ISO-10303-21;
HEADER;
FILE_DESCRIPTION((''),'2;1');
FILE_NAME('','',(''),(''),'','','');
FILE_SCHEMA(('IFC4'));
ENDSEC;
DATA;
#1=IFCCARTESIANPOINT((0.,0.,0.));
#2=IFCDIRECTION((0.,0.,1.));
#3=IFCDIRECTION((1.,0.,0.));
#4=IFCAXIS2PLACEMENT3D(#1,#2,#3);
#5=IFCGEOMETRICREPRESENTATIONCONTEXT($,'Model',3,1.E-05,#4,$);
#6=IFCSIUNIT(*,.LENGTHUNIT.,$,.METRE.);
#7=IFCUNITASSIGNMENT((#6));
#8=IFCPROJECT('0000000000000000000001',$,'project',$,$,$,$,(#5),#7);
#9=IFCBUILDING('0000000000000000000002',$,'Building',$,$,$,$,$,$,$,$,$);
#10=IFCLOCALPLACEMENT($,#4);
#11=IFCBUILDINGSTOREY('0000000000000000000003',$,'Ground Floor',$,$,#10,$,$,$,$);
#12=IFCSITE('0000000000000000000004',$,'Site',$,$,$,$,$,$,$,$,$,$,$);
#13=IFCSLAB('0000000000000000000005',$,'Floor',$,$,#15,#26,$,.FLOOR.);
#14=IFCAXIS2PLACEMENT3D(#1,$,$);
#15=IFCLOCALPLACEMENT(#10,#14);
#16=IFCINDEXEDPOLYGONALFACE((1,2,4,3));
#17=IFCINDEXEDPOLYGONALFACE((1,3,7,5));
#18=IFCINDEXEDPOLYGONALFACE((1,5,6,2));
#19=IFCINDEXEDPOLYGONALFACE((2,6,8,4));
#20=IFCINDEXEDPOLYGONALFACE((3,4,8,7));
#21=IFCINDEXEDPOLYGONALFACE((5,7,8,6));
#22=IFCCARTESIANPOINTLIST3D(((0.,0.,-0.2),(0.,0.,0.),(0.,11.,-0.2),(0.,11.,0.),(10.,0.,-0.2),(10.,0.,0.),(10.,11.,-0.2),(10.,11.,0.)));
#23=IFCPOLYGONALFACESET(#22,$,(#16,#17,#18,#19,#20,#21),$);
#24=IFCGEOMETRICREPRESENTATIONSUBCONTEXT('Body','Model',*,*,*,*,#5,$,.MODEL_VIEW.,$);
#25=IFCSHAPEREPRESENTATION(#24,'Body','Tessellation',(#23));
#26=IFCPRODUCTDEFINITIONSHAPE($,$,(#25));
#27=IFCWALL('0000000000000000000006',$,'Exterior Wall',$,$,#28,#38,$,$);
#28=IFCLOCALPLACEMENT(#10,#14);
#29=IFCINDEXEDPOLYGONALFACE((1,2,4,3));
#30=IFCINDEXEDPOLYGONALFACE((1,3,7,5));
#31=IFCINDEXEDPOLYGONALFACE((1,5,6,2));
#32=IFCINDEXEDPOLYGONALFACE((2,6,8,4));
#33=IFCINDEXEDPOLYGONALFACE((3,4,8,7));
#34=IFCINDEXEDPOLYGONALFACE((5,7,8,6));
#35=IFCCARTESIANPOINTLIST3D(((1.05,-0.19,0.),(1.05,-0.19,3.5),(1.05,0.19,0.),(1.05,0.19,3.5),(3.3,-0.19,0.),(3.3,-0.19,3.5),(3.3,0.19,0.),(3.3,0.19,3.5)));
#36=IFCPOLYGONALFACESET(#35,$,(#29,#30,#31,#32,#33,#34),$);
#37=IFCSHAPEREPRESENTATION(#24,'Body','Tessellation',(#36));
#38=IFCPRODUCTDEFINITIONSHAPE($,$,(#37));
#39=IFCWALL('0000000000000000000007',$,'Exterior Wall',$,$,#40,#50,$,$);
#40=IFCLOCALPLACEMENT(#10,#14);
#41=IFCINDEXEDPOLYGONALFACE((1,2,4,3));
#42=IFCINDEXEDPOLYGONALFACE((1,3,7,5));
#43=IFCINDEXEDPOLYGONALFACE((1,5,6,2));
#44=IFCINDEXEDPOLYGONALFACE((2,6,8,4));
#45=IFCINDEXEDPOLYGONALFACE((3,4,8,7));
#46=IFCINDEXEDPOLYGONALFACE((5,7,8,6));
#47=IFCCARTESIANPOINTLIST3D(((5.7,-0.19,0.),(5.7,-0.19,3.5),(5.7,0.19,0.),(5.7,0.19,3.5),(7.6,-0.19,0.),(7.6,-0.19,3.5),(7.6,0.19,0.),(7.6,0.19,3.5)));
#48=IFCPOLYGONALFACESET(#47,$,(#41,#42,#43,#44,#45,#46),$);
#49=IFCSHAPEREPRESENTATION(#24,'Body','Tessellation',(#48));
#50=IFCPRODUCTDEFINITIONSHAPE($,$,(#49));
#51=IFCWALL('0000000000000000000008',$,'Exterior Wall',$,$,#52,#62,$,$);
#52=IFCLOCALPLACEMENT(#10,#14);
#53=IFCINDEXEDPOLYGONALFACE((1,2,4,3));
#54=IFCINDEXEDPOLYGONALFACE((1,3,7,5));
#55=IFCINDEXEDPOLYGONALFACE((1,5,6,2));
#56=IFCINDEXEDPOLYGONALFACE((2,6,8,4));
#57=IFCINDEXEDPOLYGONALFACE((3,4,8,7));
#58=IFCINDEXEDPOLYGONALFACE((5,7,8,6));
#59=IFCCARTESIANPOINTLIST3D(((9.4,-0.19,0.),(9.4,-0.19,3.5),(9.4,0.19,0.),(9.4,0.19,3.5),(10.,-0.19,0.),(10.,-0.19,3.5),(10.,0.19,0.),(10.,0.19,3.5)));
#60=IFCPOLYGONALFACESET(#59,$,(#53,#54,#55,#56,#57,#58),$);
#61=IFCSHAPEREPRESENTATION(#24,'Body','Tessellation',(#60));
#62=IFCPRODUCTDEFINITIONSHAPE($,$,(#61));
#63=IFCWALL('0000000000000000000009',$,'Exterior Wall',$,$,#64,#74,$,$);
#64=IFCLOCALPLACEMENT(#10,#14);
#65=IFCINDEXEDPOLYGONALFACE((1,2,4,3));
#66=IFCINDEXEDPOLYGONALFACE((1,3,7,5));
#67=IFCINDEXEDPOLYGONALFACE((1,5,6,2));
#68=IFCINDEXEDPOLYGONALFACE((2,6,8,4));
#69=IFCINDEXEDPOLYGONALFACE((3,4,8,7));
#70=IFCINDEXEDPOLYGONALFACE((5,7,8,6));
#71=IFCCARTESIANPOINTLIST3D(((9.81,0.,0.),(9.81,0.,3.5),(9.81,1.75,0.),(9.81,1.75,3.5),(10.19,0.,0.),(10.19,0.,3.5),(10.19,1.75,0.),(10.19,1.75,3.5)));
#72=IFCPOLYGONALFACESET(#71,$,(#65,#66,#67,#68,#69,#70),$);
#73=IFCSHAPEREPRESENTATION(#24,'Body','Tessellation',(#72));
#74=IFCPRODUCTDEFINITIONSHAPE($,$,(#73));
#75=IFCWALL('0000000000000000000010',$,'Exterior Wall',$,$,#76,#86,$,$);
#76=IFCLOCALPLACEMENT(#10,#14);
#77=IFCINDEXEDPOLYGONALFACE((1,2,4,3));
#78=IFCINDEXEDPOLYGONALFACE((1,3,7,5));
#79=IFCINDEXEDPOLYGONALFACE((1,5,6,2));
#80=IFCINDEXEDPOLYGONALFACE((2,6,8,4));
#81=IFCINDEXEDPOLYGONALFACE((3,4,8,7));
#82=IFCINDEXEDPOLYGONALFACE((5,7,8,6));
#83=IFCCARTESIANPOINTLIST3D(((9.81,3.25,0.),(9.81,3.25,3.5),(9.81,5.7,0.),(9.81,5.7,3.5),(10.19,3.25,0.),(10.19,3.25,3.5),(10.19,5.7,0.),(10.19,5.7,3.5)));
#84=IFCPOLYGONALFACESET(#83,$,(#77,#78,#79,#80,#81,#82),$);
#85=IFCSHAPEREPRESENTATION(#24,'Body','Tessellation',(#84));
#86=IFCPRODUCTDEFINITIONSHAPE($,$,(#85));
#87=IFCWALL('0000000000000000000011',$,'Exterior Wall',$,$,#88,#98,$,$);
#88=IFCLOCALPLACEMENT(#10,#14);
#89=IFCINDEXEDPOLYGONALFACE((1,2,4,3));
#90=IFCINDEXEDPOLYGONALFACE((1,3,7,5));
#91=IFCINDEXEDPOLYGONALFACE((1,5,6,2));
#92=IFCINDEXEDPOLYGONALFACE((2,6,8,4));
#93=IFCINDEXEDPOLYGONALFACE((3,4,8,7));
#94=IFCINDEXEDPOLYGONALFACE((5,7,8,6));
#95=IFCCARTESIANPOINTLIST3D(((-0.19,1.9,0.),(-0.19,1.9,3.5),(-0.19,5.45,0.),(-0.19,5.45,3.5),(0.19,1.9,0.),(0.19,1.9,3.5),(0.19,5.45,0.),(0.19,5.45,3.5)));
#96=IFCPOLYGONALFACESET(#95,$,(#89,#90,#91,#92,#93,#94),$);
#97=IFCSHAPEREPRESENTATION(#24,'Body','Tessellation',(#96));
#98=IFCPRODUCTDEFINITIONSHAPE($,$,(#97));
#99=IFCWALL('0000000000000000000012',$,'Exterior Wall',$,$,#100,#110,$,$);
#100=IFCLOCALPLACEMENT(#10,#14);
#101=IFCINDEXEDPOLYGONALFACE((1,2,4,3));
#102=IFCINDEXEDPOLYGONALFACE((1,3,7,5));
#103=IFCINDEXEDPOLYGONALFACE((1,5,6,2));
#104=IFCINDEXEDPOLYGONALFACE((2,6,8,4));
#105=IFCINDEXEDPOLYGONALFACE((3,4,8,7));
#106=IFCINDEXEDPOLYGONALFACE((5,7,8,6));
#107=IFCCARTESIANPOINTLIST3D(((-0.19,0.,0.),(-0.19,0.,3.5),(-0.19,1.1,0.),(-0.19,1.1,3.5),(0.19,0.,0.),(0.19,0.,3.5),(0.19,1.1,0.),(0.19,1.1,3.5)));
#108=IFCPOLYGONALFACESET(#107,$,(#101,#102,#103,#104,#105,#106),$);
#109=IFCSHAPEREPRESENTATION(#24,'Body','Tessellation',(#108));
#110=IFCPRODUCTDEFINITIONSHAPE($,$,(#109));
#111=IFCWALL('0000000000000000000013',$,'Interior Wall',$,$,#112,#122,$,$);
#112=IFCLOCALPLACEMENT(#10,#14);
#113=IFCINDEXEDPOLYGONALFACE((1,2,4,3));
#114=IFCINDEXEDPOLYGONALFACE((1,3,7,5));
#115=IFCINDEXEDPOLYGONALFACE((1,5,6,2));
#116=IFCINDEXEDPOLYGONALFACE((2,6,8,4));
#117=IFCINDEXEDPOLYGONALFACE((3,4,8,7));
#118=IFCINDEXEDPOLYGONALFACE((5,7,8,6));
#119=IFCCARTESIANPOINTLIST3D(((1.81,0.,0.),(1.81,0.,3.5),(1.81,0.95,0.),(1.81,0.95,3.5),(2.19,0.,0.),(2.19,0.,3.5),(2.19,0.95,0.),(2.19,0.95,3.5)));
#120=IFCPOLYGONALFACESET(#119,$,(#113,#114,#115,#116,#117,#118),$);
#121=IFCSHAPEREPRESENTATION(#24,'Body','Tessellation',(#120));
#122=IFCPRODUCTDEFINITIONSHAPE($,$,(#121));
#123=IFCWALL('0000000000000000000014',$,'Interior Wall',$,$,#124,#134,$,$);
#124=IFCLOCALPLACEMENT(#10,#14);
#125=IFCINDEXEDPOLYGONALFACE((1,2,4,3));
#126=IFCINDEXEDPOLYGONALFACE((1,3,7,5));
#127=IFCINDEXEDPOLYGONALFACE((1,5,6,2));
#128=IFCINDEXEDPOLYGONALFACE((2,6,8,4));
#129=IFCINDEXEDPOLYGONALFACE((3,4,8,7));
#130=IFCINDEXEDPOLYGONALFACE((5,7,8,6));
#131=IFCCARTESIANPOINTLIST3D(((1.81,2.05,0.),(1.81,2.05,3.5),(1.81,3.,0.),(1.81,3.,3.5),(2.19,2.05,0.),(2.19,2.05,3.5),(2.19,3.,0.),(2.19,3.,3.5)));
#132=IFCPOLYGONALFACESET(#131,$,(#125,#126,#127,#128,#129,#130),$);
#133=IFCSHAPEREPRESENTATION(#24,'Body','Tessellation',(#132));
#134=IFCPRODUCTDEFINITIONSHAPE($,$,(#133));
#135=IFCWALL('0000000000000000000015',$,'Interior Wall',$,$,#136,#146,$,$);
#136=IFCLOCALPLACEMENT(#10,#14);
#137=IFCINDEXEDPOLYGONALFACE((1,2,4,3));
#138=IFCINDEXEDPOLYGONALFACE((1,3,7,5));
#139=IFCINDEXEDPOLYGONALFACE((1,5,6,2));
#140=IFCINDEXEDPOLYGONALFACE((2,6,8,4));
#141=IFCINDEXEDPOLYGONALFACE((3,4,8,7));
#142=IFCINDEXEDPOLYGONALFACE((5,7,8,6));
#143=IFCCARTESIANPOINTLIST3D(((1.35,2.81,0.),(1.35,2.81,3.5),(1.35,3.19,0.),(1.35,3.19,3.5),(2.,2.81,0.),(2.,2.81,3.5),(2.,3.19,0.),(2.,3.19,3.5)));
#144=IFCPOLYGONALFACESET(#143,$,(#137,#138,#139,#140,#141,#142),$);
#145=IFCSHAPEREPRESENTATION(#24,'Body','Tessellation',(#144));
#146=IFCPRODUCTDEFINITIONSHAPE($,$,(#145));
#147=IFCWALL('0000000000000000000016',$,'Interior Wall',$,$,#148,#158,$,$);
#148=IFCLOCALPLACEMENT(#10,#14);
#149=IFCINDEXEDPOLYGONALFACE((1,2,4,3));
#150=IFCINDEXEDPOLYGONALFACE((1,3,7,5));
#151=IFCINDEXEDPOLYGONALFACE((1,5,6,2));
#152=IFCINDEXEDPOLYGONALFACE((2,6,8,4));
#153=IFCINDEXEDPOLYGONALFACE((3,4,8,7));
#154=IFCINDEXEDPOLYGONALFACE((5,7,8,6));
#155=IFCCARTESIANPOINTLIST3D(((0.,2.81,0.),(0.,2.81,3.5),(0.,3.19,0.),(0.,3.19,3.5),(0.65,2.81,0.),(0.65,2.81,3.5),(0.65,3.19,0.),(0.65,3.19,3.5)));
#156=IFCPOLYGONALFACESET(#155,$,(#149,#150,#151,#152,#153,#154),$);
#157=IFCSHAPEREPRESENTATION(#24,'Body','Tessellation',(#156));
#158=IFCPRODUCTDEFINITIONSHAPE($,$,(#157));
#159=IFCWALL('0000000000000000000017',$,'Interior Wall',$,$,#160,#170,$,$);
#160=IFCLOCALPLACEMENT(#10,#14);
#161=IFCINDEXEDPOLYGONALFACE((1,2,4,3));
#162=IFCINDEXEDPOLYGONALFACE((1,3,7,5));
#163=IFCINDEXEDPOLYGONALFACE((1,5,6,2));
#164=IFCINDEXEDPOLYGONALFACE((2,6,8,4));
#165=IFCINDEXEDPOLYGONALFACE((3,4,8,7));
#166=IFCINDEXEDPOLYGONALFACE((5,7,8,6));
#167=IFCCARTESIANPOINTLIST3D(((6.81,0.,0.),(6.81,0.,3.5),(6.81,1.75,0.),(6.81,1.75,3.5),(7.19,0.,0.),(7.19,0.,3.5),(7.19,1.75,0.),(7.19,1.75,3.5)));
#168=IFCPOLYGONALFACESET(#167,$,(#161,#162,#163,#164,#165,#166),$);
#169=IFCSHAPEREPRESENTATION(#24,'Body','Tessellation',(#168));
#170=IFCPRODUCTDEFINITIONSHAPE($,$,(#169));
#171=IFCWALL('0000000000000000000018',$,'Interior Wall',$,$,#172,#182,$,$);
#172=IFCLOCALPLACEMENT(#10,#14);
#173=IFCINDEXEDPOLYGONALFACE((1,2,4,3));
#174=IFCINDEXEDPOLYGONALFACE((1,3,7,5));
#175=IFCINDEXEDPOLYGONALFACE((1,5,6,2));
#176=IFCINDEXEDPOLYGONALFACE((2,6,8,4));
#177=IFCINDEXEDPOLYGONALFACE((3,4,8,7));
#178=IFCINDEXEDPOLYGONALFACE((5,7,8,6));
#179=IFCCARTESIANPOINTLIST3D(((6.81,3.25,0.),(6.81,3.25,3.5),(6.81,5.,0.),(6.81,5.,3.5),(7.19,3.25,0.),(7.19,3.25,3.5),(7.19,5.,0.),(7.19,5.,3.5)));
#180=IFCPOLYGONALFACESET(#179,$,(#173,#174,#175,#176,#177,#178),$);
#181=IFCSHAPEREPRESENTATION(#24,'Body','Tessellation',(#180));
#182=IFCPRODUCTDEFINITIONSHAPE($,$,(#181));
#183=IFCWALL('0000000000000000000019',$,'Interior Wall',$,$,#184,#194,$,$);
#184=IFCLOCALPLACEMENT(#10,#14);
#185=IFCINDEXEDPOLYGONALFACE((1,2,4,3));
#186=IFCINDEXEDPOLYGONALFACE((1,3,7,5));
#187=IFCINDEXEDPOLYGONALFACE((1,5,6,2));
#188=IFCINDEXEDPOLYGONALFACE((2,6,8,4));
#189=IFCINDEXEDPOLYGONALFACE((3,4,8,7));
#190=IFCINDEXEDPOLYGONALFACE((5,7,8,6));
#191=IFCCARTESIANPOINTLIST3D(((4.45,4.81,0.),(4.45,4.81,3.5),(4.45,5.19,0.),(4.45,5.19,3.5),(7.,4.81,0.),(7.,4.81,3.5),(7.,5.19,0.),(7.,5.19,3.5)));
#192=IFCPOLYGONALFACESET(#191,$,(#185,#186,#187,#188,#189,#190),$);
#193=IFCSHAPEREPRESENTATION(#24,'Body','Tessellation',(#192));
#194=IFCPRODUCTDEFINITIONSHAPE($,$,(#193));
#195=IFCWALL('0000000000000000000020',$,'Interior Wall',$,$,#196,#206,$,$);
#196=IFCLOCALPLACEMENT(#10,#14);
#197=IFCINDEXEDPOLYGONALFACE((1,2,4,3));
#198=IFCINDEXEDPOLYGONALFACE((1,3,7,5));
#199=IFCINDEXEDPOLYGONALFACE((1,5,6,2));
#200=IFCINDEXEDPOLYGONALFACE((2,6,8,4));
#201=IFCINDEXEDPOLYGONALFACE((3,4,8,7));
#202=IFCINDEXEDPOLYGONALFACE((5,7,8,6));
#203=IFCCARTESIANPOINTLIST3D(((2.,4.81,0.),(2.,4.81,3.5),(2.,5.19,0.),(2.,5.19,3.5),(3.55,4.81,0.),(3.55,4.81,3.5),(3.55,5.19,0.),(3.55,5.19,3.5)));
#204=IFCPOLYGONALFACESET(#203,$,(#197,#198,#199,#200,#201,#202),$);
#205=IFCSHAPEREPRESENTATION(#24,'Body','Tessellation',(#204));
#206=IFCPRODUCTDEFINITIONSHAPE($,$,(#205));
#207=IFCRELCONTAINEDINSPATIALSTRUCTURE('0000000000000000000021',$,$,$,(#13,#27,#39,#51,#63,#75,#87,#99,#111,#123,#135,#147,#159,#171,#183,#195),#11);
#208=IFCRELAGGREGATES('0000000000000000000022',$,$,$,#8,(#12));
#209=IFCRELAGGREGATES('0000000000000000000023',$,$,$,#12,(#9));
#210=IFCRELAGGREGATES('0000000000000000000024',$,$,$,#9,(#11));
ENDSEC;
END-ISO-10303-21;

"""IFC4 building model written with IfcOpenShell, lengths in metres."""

from ifc_helpers import new_model, si_unit, frame, origin_with_axes, place, context, subcontext, project, spatial, indexed_curve, outline, extrude, element, save


model = new_model("IFC4")

# Units and contexts
model_context = context("Model", 3, precision=1e-05, world=origin_with_axes())
body_context = subcontext(model_context, "Body", "Model", "MODEL_VIEW")
ifc_project = project(units=[si_unit("LENGTHUNIT", "METRE")], contexts=[model_context])

# Site, building, storey
site = spatial("IfcSite", under=ifc_project, Name="Site")
building = spatial("IfcBuilding", under=site, Name="Building")
storey_placement = place(None, origin_with_axes())
storey = spatial("IfcBuildingStorey", under=building, at=storey_placement, Name="Ground Floor")

# Slab
slab_placement = place(storey_placement, frame((0.0, 0.0, -0.2), z_axis=(0.0, 0.0, 1.0), x_axis=(1.0, 0.0, 0.0)))
element("IfcSlab", 1, at=slab_placement, inside=storey, Name="Floor", PredefinedType="FLOOR", context=body_context, shape_type="SweptSolid", body=[
    extrude(outline(indexed_curve([(0.0, 0.0), (10.0, 0.0), (10.0, 11.0), (0.0, 11.0)])), None, (0.0, 0.0, 1.0), 0.2),
])

# Walls
wall_1_placement = place(storey_placement, frame((1.05, 0.0, 0.0), z_axis=(0.0, 0.0, 1.0), x_axis=(1.0, 0.0, 0.0)))
element("IfcWall", 2, at=wall_1_placement, inside=storey, Name="Exterior Wall", context=body_context, shape_type="SweptSolid", body=[
    extrude(outline(indexed_curve([(0.0, 0.0), (0.0, 0.38), (2.25, 0.38), (2.25, 0.0), (0.0, 0.0)], self_intersect=False)), frame((0.0, -0.19, 0.0), z_axis=(0.0, 0.0, 1.0), x_axis=(1.0, 0.0, 0.0)), (0.0, 0.0, 1.0), 3.5),
])
wall_2_placement = place(storey_placement, frame((5.7, 0.0, 0.0), z_axis=(0.0, 0.0, 1.0), x_axis=(1.0, 0.0, 0.0)))
element("IfcWall", 3, at=wall_2_placement, inside=storey, Name="Exterior Wall", context=body_context, shape_type="SweptSolid", body=[
    extrude(outline(indexed_curve([(0.0, 0.0), (0.0, 0.38), (1.9, 0.38), (1.9, 0.0), (0.0, 0.0)], self_intersect=False)), frame((0.0, -0.19, 0.0), z_axis=(0.0, 0.0, 1.0), x_axis=(1.0, 0.0, 0.0)), (0.0, 0.0, 1.0), 3.5),
])
wall_3_placement = place(storey_placement, frame((9.4, 0.0, 0.0), z_axis=(0.0, 0.0, 1.0), x_axis=(1.0, 0.0, 0.0)))
element("IfcWall", 4, at=wall_3_placement, inside=storey, Name="Exterior Wall", context=body_context, shape_type="SweptSolid", body=[
    extrude(outline(indexed_curve([(0.0, 0.0), (0.0, 0.38), (0.6, 0.38), (0.6, 0.0), (0.0, 0.0)], self_intersect=False)), frame((0.0, -0.19, 0.0), z_axis=(0.0, 0.0, 1.0), x_axis=(1.0, 0.0, 0.0)), (0.0, 0.0, 1.0), 3.5),
])
wall_4_placement = place(storey_placement, frame((10.0, 0.0, 0.0), z_axis=(0.0, 0.0, 1.0), x_axis=(0.0, 1.0, 0.0)))
element("IfcWall", 5, at=wall_4_placement, inside=storey, Name="Exterior Wall", context=body_context, shape_type="SweptSolid", body=[
    extrude(outline(indexed_curve([(0.0, 0.0), (0.0, 0.38), (1.75, 0.38), (1.75, 0.0), (0.0, 0.0)], self_intersect=False)), frame((0.0, -0.19, 0.0), z_axis=(0.0, 0.0, 1.0), x_axis=(1.0, 0.0, 0.0)), (0.0, 0.0, 1.0), 3.5),
])
wall_5_placement = place(storey_placement, frame((10.0, 3.25, 0.0), z_axis=(0.0, 0.0, 1.0), x_axis=(0.0, 1.0, 0.0)))
element("IfcWall", 6, at=wall_5_placement, inside=storey, Name="Exterior Wall", context=body_context, shape_type="SweptSolid", body=[
    extrude(outline(indexed_curve([(0.0, 0.0), (0.0, 0.38), (2.45, 0.38), (2.45, 0.0), (0.0, 0.0)], self_intersect=False)), frame((0.0, -0.19, 0.0), z_axis=(0.0, 0.0, 1.0), x_axis=(1.0, 0.0, 0.0)), (0.0, 0.0, 1.0), 3.5),
])
wall_6_placement = place(storey_placement, frame((0.0, 5.45, 0.0), z_axis=(0.0, 0.0, 1.0), x_axis=(0.0, -1.0, 0.0)))
element("IfcWall", 7, at=wall_6_placement, inside=storey, Name="Exterior Wall", context=body_context, shape_type="SweptSolid", body=[
    extrude(outline(indexed_curve([(0.0, 0.0), (0.0, 0.38), (3.55, 0.38), (3.55, 0.0), (0.0, 0.0)], self_intersect=False)), frame((0.0, -0.19, 0.0), z_axis=(0.0, 0.0, 1.0), x_axis=(1.0, 0.0, 0.0)), (0.0, 0.0, 1.0), 3.5),
])
wall_7_placement = place(storey_placement, frame((0.0, 1.1, 0.0), z_axis=(0.0, 0.0, 1.0), x_axis=(0.0, -1.0, 0.0)))
element("IfcWall", 8, at=wall_7_placement, inside=storey, Name="Exterior Wall", context=body_context, shape_type="SweptSolid", body=[
    extrude(outline(indexed_curve([(0.0, 0.0), (0.0, 0.38), (1.1, 0.38), (1.1, 0.0), (0.0, 0.0)], self_intersect=False)), frame((0.0, -0.19, 0.0), z_axis=(0.0, 0.0, 1.0), x_axis=(1.0, 0.0, 0.0)), (0.0, 0.0, 1.0), 3.5),
])
wall_8_placement = place(storey_placement, frame((2.0, 0.0, 0.0), z_axis=(0.0, 0.0, 1.0), x_axis=(0.0, 1.0, 0.0)))
element("IfcWall", 9, at=wall_8_placement, inside=storey, Name="Interior Wall", context=body_context, shape_type="SweptSolid", body=[
    extrude(outline(indexed_curve([(0.0, 0.0), (0.0, 0.38), (0.95, 0.38), (0.95, 0.0), (0.0, 0.0)], self_intersect=False)), frame((0.0, -0.19, 0.0), z_axis=(0.0, 0.0, 1.0), x_axis=(1.0, 0.0, 0.0)), (0.0, 0.0, 1.0), 3.5),
])
wall_9_placement = place(storey_placement, frame((2.0, 2.05, 0.0), z_axis=(0.0, 0.0, 1.0), x_axis=(0.0, 1.0, 0.0)))
element("IfcWall", 10, at=wall_9_placement, inside=storey, Name="Interior Wall", context=body_context, shape_type="SweptSolid", body=[
    extrude(outline(indexed_curve([(0.0, 0.0), (0.0, 0.38), (0.95, 0.38), (0.95, 0.0), (0.0, 0.0)], self_intersect=False)), frame((0.0, -0.19, 0.0), z_axis=(0.0, 0.0, 1.0), x_axis=(1.0, 0.0, 0.0)), (0.0, 0.0, 1.0), 3.5),
])
for number, where, z_axis, x_axis, name in (
    (11, (2.0, 3.0, 0.0), (0.0, 0.0, 1.0), (-1.0, 0.0, 0.0), "Interior Wall"),
    (12, (0.65, 3.0, 0.0), (0.0, 0.0, 1.0), (-1.0, 0.0, 0.0), "Interior Wall"),
):
    element("IfcWall", number, at=place(storey_placement, frame(where, z_axis=z_axis, x_axis=x_axis)), inside=storey, Name=name, context=body_context, shape_type="SweptSolid", body=[
        extrude(outline(indexed_curve([(0.0, 0.0), (0.0, 0.38), (0.65, 0.38), (0.65, 0.0), (0.0, 0.0)], self_intersect=False)), frame((0.0, -0.19, 0.0), z_axis=(0.0, 0.0, 1.0), x_axis=(1.0, 0.0, 0.0)), (0.0, 0.0, 1.0), 3.5),
    ])
for number, where, z_axis, x_axis, name in (
    (13, (7.0, 0.0, 0.0), (0.0, 0.0, 1.0), (0.0, 1.0, 0.0), "Interior Wall"),
    (14, (7.0, 3.25, 0.0), (0.0, 0.0, 1.0), (0.0, 1.0, 0.0), "Interior Wall"),
):
    element("IfcWall", number, at=place(storey_placement, frame(where, z_axis=z_axis, x_axis=x_axis)), inside=storey, Name=name, context=body_context, shape_type="SweptSolid", body=[
        extrude(outline(indexed_curve([(0.0, 0.0), (0.0, 0.38), (1.75, 0.38), (1.75, 0.0), (0.0, 0.0)], self_intersect=False)), frame((0.0, -0.19, 0.0), z_axis=(0.0, 0.0, 1.0), x_axis=(1.0, 0.0, 0.0)), (0.0, 0.0, 1.0), 3.5),
    ])
wall_10_placement = place(storey_placement, frame((7.0, 5.0, 0.0), z_axis=(0.0, 0.0, 1.0), x_axis=(-1.0, 0.0, 0.0)))
element("IfcWall", 15, at=wall_10_placement, inside=storey, Name="Interior Wall", context=body_context, shape_type="SweptSolid", body=[
    extrude(outline(indexed_curve([(0.0, 0.0), (0.0, 0.38), (2.55, 0.38), (2.55, 0.0), (0.0, 0.0)], self_intersect=False)), frame((0.0, -0.19, 0.0), z_axis=(0.0, 0.0, 1.0), x_axis=(1.0, 0.0, 0.0)), (0.0, 0.0, 1.0), 3.5),
])
wall_11_placement = place(storey_placement, frame((3.55, 5.0, 0.0), z_axis=(0.0, 0.0, 1.0), x_axis=(-1.0, 0.0, 0.0)))
element("IfcWall", 16, at=wall_11_placement, inside=storey, Name="Interior Wall", context=body_context, shape_type="SweptSolid", body=[
    extrude(outline(indexed_curve([(0.0, 0.0), (0.0, 0.38), (1.55, 0.38), (1.55, 0.0), (0.0, 0.0)], self_intersect=False)), frame((0.0, -0.19, 0.0), z_axis=(0.0, 0.0, 1.0), x_axis=(1.0, 0.0, 0.0)), (0.0, 0.0, 1.0), 3.5),
])

save(model, "model.ifc")
